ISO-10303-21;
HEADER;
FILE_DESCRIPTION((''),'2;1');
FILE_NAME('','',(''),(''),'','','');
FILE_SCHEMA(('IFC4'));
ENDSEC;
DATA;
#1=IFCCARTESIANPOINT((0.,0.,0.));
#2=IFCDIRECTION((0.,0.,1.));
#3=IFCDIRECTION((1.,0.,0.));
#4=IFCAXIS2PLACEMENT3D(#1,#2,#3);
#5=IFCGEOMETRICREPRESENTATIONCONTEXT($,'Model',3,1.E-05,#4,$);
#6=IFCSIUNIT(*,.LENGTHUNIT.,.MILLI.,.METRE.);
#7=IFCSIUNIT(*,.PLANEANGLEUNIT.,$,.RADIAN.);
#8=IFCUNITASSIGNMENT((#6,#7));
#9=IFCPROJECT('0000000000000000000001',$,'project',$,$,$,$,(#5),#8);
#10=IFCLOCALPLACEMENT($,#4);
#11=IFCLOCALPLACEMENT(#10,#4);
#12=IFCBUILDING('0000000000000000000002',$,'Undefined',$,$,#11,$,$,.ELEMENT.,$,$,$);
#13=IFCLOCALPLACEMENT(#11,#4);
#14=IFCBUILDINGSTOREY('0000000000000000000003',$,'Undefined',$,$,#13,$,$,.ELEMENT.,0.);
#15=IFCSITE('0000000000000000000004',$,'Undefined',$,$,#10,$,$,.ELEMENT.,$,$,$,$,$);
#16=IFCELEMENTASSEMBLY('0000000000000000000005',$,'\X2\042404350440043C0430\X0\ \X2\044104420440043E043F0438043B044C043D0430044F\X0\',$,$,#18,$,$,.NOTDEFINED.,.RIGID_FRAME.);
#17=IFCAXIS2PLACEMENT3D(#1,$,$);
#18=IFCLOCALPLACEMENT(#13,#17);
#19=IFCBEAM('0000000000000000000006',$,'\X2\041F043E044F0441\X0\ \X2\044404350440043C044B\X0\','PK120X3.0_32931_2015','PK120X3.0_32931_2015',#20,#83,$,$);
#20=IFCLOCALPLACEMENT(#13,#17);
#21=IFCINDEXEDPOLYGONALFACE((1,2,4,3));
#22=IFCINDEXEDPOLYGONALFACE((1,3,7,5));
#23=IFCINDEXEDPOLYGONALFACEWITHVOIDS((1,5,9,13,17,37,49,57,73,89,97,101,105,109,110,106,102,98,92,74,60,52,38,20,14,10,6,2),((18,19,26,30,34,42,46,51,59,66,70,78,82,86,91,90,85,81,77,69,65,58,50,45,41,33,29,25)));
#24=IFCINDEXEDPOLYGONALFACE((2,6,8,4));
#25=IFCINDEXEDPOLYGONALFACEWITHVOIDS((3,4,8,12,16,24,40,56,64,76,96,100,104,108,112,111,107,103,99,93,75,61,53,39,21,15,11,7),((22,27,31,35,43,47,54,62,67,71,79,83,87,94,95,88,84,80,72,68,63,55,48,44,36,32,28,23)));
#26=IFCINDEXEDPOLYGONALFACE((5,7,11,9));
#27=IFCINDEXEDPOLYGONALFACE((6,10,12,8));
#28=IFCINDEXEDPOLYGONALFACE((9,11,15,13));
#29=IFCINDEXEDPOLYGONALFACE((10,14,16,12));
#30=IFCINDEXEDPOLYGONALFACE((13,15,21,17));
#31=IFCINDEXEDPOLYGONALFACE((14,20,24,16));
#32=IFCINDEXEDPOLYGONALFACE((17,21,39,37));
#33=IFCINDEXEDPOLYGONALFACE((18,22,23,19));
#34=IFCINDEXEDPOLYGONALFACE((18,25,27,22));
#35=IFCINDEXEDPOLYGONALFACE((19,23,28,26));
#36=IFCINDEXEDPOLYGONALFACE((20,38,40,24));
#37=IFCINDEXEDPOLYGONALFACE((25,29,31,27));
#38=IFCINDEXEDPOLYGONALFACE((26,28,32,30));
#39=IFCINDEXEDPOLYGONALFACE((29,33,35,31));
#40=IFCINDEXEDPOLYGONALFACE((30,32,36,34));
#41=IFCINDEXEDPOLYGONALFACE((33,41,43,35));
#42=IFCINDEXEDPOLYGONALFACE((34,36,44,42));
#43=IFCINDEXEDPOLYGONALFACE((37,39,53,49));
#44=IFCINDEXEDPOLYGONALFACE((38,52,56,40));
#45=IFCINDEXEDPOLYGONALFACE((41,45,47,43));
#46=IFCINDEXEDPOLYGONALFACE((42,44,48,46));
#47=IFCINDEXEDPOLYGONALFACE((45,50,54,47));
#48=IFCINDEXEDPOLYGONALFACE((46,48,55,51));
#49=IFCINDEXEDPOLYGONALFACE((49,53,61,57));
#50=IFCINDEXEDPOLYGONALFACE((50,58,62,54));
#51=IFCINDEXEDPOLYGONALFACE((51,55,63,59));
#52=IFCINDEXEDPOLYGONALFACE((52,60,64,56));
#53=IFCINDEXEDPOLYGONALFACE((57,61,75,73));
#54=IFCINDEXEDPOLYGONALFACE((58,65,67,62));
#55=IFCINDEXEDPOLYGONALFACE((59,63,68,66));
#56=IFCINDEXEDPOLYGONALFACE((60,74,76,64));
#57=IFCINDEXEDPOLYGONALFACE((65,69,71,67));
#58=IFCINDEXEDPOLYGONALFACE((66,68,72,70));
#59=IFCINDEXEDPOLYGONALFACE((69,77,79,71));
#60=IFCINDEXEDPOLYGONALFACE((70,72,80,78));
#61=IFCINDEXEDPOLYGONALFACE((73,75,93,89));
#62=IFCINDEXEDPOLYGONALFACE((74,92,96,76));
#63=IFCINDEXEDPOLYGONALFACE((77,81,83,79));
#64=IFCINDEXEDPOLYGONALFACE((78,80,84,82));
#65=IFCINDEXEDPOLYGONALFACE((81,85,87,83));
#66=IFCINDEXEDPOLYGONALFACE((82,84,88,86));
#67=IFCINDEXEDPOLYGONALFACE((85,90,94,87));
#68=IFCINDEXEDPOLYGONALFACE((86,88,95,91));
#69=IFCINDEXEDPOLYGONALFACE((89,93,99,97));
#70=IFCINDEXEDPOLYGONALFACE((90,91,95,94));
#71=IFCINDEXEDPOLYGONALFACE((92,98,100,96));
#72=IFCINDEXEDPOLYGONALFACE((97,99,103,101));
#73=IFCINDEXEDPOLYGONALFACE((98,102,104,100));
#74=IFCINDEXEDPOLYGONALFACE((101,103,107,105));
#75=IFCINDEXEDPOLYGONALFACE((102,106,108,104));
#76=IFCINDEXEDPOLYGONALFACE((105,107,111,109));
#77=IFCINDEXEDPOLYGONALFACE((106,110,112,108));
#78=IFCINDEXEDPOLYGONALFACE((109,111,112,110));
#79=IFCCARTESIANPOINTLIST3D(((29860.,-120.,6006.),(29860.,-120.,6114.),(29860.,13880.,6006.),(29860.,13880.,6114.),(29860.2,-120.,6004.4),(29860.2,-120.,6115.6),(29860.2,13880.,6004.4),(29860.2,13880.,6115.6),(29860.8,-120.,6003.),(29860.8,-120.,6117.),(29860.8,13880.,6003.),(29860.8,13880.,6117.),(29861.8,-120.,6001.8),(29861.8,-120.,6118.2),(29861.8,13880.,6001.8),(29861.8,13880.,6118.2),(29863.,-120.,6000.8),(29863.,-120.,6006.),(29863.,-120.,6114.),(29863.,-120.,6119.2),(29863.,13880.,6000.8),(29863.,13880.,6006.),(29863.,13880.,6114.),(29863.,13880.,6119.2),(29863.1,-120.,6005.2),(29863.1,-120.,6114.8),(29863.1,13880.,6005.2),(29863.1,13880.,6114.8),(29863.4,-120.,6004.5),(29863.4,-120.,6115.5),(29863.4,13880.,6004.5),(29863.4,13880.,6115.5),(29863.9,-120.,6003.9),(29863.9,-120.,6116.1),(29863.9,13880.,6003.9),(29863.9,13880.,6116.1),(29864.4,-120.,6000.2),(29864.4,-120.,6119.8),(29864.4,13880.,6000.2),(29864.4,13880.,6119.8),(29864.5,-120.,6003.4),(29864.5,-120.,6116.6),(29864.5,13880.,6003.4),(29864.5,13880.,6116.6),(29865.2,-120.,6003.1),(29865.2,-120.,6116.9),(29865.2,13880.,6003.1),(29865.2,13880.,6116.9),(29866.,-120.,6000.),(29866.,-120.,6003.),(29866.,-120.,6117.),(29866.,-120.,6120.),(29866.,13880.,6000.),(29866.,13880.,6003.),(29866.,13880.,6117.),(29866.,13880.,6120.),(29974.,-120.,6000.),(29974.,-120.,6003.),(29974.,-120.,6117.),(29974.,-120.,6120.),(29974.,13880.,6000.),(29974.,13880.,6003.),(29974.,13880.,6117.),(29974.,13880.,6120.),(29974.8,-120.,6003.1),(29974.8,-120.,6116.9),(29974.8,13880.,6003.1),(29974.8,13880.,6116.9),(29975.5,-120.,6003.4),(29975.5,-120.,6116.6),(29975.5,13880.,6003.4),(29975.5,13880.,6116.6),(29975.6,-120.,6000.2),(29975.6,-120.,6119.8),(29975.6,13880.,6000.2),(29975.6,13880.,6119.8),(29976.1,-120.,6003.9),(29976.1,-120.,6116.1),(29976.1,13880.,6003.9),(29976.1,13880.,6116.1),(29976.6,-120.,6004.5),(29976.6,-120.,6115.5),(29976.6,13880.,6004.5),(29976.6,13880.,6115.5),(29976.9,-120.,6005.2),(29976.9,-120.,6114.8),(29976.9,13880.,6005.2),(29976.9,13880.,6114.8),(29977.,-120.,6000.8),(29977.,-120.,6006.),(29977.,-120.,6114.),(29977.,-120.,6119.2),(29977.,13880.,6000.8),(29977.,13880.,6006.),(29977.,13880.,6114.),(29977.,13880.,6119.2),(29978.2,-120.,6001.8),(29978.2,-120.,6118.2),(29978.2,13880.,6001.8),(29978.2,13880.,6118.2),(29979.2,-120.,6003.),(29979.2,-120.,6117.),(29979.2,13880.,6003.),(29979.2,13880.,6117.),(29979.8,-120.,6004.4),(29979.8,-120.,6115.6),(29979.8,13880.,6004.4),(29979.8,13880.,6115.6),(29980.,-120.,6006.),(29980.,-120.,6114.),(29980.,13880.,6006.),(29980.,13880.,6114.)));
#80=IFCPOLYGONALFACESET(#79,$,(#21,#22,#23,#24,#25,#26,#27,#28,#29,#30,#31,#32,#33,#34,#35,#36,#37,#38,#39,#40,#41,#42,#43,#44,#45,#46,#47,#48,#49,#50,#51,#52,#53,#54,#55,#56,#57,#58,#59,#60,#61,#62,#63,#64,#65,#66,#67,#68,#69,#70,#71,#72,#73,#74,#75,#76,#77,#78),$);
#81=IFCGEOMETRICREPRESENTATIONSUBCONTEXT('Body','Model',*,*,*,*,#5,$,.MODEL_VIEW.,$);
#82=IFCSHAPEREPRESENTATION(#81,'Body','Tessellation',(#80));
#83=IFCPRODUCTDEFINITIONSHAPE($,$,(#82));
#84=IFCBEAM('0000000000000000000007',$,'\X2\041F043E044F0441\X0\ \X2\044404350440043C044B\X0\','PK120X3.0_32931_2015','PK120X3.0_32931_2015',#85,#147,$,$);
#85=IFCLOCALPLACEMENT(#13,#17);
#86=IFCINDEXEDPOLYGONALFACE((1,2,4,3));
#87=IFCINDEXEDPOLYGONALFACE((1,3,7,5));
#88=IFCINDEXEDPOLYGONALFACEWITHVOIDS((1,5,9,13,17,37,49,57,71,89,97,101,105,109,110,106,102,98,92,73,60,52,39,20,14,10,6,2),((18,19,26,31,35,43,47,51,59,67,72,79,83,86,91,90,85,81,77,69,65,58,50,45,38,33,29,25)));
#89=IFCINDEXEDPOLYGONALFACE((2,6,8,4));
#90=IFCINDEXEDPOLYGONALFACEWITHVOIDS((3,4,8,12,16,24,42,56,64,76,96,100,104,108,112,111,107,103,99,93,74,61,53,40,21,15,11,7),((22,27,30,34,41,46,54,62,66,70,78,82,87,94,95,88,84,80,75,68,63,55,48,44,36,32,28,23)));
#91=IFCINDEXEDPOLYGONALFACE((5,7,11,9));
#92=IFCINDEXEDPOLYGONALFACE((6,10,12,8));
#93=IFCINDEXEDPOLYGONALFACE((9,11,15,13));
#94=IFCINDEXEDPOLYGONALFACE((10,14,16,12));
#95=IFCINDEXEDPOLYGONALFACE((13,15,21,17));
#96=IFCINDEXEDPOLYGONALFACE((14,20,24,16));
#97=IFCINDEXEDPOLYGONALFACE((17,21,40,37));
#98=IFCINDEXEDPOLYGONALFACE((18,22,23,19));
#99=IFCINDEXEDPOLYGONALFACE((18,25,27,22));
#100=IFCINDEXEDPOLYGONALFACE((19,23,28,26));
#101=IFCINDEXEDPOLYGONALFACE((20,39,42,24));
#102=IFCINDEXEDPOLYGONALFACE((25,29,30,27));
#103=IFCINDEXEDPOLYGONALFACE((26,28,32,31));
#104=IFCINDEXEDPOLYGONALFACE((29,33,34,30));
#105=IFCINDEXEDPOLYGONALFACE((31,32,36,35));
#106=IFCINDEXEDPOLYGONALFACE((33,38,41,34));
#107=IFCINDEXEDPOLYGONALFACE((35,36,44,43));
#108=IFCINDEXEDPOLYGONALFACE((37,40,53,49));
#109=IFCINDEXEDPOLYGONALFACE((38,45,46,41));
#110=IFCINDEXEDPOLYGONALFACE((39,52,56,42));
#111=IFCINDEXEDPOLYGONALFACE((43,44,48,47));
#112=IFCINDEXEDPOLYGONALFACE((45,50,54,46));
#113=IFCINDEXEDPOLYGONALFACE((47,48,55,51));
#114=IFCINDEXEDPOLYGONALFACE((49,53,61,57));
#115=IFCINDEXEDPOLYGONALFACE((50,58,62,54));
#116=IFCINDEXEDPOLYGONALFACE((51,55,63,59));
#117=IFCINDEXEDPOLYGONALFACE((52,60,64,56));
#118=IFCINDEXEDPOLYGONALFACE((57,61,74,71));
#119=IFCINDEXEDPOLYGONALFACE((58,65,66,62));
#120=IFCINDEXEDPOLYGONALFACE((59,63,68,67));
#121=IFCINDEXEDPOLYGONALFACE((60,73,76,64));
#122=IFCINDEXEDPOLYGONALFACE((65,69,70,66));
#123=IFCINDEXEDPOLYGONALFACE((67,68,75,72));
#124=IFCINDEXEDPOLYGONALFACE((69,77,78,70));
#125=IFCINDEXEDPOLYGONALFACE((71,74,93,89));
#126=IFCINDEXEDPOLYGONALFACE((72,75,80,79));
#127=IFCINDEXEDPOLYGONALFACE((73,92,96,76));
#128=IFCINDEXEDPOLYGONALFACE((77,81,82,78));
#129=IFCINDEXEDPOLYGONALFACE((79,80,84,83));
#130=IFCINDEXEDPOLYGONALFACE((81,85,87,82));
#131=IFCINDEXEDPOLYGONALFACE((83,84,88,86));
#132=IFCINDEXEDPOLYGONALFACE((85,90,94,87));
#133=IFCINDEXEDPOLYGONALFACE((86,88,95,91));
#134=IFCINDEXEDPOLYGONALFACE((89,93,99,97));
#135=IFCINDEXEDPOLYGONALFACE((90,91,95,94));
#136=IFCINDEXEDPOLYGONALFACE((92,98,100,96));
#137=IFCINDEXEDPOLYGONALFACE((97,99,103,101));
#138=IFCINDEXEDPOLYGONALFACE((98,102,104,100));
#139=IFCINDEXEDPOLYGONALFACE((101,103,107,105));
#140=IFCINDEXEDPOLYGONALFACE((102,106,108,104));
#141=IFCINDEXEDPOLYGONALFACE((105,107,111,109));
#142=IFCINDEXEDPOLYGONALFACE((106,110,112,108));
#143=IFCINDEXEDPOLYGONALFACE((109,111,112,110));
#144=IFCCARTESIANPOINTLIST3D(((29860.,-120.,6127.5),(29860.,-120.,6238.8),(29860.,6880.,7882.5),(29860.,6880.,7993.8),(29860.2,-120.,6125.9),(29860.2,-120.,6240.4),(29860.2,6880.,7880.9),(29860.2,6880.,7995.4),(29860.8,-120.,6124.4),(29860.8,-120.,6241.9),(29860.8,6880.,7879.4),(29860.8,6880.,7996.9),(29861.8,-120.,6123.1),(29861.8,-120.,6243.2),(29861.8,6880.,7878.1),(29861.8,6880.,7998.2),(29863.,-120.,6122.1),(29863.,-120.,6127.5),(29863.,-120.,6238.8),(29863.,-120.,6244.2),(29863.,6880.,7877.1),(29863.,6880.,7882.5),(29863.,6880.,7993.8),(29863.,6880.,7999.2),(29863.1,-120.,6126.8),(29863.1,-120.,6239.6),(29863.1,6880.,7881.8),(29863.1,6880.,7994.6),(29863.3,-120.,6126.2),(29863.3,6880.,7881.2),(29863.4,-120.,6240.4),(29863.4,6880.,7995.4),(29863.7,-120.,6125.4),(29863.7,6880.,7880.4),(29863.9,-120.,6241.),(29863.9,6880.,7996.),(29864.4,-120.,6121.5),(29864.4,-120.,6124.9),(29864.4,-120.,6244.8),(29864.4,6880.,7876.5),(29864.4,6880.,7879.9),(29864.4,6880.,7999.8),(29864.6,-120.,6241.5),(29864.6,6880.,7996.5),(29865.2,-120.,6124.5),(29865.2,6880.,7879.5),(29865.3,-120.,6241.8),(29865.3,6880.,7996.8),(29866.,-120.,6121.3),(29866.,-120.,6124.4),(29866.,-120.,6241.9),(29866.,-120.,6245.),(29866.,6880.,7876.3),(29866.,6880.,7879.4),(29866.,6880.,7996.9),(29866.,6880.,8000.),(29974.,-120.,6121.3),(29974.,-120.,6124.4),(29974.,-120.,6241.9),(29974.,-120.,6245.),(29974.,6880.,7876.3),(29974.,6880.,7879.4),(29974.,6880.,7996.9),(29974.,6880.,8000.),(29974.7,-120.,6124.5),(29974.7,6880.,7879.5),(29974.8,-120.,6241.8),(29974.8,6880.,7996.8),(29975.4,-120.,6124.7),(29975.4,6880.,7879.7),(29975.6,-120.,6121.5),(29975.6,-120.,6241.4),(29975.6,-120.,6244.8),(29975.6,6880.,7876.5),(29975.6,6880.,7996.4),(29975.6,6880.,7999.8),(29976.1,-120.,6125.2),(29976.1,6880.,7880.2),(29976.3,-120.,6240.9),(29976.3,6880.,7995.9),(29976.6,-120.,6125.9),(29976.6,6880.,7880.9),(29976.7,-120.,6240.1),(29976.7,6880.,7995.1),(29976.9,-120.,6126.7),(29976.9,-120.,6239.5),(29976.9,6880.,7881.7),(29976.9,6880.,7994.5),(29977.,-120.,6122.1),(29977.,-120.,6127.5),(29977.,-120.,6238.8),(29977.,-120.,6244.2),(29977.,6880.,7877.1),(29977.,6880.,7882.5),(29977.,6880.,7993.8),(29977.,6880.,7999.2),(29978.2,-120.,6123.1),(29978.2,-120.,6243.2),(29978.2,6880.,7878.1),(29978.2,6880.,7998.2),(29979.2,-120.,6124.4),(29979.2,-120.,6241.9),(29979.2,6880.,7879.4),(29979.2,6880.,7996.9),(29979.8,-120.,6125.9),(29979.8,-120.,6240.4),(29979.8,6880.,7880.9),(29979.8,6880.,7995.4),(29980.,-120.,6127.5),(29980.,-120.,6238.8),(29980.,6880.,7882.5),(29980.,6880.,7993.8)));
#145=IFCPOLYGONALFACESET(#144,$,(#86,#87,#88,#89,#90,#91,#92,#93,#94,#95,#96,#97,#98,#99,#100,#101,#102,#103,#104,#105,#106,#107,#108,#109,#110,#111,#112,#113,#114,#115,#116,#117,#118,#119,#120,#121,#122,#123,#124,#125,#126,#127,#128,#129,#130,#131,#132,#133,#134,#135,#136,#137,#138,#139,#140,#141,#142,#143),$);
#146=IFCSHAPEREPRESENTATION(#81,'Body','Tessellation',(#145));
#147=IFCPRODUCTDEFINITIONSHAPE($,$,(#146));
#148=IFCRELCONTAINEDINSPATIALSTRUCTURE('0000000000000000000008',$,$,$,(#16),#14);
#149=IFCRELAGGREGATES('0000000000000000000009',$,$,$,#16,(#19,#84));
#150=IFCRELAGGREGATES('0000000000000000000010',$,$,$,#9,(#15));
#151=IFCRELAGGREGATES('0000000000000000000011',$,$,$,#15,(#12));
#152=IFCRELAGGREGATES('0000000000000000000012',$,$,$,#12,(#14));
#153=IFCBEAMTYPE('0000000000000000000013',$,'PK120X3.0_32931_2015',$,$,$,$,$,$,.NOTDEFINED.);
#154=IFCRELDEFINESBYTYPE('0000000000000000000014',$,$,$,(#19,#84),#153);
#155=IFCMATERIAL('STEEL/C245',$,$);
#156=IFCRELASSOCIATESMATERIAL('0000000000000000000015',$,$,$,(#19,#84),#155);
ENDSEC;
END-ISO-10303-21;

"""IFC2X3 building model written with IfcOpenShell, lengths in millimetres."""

from ifc_helpers import new_model, si_unit, frame, origin_with_axes, origin_2d_with_axis, place, context, subcontext, project, spatial, hollow_rectangle, extrude, clip, halfspace, material, type_object, element, aggregate, save


model = new_model("IFC2X3")

# Units and contexts
model_context = context("Model", 3, precision=1e-05, world=origin_with_axes())
body_context = subcontext(model_context, "Body", "Model", "MODEL_VIEW")
ifc_project = project(units=[si_unit("LENGTHUNIT", "METRE", prefix="MILLI"), si_unit("PLANEANGLEUNIT", "RADIAN")], contexts=[model_context])

# Site, building, storey
site_placement = place(None, origin_with_axes())
site = spatial("IfcSite", under=ifc_project, at=site_placement, Name="Undefined", CompositionType="ELEMENT")
building_placement = place(site_placement, origin_with_axes())
building = spatial("IfcBuilding", under=site, at=building_placement, Name="Undefined", CompositionType="ELEMENT")
storey_placement = place(building_placement, origin_with_axes())
storey = spatial("IfcBuildingStorey", under=building, at=storey_placement, Name="Undefined", CompositionType="ELEMENT", Elevation=0.0)

# Shared definitions
ifc_material = material(Name="STEEL/C245")

# Element assembly
assembly_1_placement = place(storey_placement, origin_with_axes())
assembly_1 = element("IfcElementAssembly", 1, at=assembly_1_placement, inside=storey, Name="Ферма стропильная", AssemblyPlace="NOTDEFINED", PredefinedType="RIGID_FRAME")

# Beams
beam_type_1 = type_object("IfcBeamType", Name="PK120X3.0_32931_2015", PredefinedType="NOTDEFINED")
beam_1_placement = place(assembly_1_placement, frame((29920.0, -120.0, 6060.0), z_axis=(0.0, 0.0, 1.0), x_axis=(0.0, 1.0, 0.0)))
beam_1 = element("IfcBeam", 2, at=beam_1_placement, type_object=beam_type_1, material=ifc_material, Name="Пояс фермы", Description="PK120X3.0_32931_2015", ObjectType="PK120X3.0_32931_2015", context=body_context, shape_type="SweptSolid", body=[
    extrude(hollow_rectangle(XDim=120.0, YDim=120.0, WallThickness=3.0, InnerFilletRadius=3.0, OuterFilletRadius=6.0, at=origin_2d_with_axis()), frame((14000.0, 0.0, 0.0), z_axis=(-1.0, 0.0, 0.0), x_axis=(0.0, -1.0, 0.0)), (0.0, 0.0, 1.0), 14000.0),
])
beam_2_placement = place(assembly_1_placement, frame((29920.0, -105.4, 6186.8), z_axis=(0.0, -0.243188, 0.969979), x_axis=(0.0, 0.969979, 0.243188)))
beam_2 = element("IfcBeam", 3, at=beam_2_placement, type_object=beam_type_1, material=ifc_material, Name="Пояс фермы", Description="PK120X3.0_32931_2015", ObjectType="PK120X3.0_32931_2015", context=body_context, shape_type="Clipping", body=[
    clip(clip(extrude(hollow_rectangle(XDim=120.0, YDim=120.0, WallThickness=3.0, InnerFilletRadius=3.0, OuterFilletRadius=6.0, at=origin_2d_with_axis()), frame((7232.0, 0.0, 0.0), z_axis=(-1.0, 0.0, 0.0), x_axis=(0.0, -1.0, 0.0)), (0.0, 0.0, 1.0), 7277.4), halfspace(frame((7216.6, 0.0, 60.0), z_axis=(0.969979, 0.0, -0.243188), x_axis=(0.0, -1.0, 0.0)), False)), halfspace(frame((0.0, 0.0, 60.0), z_axis=(0.969979, 0.0, -0.243188), x_axis=(0.0, -1.0, 0.0)), True)),
])
aggregate(assembly_1, [beam_1, beam_2])

save(model, "model.ifc")
